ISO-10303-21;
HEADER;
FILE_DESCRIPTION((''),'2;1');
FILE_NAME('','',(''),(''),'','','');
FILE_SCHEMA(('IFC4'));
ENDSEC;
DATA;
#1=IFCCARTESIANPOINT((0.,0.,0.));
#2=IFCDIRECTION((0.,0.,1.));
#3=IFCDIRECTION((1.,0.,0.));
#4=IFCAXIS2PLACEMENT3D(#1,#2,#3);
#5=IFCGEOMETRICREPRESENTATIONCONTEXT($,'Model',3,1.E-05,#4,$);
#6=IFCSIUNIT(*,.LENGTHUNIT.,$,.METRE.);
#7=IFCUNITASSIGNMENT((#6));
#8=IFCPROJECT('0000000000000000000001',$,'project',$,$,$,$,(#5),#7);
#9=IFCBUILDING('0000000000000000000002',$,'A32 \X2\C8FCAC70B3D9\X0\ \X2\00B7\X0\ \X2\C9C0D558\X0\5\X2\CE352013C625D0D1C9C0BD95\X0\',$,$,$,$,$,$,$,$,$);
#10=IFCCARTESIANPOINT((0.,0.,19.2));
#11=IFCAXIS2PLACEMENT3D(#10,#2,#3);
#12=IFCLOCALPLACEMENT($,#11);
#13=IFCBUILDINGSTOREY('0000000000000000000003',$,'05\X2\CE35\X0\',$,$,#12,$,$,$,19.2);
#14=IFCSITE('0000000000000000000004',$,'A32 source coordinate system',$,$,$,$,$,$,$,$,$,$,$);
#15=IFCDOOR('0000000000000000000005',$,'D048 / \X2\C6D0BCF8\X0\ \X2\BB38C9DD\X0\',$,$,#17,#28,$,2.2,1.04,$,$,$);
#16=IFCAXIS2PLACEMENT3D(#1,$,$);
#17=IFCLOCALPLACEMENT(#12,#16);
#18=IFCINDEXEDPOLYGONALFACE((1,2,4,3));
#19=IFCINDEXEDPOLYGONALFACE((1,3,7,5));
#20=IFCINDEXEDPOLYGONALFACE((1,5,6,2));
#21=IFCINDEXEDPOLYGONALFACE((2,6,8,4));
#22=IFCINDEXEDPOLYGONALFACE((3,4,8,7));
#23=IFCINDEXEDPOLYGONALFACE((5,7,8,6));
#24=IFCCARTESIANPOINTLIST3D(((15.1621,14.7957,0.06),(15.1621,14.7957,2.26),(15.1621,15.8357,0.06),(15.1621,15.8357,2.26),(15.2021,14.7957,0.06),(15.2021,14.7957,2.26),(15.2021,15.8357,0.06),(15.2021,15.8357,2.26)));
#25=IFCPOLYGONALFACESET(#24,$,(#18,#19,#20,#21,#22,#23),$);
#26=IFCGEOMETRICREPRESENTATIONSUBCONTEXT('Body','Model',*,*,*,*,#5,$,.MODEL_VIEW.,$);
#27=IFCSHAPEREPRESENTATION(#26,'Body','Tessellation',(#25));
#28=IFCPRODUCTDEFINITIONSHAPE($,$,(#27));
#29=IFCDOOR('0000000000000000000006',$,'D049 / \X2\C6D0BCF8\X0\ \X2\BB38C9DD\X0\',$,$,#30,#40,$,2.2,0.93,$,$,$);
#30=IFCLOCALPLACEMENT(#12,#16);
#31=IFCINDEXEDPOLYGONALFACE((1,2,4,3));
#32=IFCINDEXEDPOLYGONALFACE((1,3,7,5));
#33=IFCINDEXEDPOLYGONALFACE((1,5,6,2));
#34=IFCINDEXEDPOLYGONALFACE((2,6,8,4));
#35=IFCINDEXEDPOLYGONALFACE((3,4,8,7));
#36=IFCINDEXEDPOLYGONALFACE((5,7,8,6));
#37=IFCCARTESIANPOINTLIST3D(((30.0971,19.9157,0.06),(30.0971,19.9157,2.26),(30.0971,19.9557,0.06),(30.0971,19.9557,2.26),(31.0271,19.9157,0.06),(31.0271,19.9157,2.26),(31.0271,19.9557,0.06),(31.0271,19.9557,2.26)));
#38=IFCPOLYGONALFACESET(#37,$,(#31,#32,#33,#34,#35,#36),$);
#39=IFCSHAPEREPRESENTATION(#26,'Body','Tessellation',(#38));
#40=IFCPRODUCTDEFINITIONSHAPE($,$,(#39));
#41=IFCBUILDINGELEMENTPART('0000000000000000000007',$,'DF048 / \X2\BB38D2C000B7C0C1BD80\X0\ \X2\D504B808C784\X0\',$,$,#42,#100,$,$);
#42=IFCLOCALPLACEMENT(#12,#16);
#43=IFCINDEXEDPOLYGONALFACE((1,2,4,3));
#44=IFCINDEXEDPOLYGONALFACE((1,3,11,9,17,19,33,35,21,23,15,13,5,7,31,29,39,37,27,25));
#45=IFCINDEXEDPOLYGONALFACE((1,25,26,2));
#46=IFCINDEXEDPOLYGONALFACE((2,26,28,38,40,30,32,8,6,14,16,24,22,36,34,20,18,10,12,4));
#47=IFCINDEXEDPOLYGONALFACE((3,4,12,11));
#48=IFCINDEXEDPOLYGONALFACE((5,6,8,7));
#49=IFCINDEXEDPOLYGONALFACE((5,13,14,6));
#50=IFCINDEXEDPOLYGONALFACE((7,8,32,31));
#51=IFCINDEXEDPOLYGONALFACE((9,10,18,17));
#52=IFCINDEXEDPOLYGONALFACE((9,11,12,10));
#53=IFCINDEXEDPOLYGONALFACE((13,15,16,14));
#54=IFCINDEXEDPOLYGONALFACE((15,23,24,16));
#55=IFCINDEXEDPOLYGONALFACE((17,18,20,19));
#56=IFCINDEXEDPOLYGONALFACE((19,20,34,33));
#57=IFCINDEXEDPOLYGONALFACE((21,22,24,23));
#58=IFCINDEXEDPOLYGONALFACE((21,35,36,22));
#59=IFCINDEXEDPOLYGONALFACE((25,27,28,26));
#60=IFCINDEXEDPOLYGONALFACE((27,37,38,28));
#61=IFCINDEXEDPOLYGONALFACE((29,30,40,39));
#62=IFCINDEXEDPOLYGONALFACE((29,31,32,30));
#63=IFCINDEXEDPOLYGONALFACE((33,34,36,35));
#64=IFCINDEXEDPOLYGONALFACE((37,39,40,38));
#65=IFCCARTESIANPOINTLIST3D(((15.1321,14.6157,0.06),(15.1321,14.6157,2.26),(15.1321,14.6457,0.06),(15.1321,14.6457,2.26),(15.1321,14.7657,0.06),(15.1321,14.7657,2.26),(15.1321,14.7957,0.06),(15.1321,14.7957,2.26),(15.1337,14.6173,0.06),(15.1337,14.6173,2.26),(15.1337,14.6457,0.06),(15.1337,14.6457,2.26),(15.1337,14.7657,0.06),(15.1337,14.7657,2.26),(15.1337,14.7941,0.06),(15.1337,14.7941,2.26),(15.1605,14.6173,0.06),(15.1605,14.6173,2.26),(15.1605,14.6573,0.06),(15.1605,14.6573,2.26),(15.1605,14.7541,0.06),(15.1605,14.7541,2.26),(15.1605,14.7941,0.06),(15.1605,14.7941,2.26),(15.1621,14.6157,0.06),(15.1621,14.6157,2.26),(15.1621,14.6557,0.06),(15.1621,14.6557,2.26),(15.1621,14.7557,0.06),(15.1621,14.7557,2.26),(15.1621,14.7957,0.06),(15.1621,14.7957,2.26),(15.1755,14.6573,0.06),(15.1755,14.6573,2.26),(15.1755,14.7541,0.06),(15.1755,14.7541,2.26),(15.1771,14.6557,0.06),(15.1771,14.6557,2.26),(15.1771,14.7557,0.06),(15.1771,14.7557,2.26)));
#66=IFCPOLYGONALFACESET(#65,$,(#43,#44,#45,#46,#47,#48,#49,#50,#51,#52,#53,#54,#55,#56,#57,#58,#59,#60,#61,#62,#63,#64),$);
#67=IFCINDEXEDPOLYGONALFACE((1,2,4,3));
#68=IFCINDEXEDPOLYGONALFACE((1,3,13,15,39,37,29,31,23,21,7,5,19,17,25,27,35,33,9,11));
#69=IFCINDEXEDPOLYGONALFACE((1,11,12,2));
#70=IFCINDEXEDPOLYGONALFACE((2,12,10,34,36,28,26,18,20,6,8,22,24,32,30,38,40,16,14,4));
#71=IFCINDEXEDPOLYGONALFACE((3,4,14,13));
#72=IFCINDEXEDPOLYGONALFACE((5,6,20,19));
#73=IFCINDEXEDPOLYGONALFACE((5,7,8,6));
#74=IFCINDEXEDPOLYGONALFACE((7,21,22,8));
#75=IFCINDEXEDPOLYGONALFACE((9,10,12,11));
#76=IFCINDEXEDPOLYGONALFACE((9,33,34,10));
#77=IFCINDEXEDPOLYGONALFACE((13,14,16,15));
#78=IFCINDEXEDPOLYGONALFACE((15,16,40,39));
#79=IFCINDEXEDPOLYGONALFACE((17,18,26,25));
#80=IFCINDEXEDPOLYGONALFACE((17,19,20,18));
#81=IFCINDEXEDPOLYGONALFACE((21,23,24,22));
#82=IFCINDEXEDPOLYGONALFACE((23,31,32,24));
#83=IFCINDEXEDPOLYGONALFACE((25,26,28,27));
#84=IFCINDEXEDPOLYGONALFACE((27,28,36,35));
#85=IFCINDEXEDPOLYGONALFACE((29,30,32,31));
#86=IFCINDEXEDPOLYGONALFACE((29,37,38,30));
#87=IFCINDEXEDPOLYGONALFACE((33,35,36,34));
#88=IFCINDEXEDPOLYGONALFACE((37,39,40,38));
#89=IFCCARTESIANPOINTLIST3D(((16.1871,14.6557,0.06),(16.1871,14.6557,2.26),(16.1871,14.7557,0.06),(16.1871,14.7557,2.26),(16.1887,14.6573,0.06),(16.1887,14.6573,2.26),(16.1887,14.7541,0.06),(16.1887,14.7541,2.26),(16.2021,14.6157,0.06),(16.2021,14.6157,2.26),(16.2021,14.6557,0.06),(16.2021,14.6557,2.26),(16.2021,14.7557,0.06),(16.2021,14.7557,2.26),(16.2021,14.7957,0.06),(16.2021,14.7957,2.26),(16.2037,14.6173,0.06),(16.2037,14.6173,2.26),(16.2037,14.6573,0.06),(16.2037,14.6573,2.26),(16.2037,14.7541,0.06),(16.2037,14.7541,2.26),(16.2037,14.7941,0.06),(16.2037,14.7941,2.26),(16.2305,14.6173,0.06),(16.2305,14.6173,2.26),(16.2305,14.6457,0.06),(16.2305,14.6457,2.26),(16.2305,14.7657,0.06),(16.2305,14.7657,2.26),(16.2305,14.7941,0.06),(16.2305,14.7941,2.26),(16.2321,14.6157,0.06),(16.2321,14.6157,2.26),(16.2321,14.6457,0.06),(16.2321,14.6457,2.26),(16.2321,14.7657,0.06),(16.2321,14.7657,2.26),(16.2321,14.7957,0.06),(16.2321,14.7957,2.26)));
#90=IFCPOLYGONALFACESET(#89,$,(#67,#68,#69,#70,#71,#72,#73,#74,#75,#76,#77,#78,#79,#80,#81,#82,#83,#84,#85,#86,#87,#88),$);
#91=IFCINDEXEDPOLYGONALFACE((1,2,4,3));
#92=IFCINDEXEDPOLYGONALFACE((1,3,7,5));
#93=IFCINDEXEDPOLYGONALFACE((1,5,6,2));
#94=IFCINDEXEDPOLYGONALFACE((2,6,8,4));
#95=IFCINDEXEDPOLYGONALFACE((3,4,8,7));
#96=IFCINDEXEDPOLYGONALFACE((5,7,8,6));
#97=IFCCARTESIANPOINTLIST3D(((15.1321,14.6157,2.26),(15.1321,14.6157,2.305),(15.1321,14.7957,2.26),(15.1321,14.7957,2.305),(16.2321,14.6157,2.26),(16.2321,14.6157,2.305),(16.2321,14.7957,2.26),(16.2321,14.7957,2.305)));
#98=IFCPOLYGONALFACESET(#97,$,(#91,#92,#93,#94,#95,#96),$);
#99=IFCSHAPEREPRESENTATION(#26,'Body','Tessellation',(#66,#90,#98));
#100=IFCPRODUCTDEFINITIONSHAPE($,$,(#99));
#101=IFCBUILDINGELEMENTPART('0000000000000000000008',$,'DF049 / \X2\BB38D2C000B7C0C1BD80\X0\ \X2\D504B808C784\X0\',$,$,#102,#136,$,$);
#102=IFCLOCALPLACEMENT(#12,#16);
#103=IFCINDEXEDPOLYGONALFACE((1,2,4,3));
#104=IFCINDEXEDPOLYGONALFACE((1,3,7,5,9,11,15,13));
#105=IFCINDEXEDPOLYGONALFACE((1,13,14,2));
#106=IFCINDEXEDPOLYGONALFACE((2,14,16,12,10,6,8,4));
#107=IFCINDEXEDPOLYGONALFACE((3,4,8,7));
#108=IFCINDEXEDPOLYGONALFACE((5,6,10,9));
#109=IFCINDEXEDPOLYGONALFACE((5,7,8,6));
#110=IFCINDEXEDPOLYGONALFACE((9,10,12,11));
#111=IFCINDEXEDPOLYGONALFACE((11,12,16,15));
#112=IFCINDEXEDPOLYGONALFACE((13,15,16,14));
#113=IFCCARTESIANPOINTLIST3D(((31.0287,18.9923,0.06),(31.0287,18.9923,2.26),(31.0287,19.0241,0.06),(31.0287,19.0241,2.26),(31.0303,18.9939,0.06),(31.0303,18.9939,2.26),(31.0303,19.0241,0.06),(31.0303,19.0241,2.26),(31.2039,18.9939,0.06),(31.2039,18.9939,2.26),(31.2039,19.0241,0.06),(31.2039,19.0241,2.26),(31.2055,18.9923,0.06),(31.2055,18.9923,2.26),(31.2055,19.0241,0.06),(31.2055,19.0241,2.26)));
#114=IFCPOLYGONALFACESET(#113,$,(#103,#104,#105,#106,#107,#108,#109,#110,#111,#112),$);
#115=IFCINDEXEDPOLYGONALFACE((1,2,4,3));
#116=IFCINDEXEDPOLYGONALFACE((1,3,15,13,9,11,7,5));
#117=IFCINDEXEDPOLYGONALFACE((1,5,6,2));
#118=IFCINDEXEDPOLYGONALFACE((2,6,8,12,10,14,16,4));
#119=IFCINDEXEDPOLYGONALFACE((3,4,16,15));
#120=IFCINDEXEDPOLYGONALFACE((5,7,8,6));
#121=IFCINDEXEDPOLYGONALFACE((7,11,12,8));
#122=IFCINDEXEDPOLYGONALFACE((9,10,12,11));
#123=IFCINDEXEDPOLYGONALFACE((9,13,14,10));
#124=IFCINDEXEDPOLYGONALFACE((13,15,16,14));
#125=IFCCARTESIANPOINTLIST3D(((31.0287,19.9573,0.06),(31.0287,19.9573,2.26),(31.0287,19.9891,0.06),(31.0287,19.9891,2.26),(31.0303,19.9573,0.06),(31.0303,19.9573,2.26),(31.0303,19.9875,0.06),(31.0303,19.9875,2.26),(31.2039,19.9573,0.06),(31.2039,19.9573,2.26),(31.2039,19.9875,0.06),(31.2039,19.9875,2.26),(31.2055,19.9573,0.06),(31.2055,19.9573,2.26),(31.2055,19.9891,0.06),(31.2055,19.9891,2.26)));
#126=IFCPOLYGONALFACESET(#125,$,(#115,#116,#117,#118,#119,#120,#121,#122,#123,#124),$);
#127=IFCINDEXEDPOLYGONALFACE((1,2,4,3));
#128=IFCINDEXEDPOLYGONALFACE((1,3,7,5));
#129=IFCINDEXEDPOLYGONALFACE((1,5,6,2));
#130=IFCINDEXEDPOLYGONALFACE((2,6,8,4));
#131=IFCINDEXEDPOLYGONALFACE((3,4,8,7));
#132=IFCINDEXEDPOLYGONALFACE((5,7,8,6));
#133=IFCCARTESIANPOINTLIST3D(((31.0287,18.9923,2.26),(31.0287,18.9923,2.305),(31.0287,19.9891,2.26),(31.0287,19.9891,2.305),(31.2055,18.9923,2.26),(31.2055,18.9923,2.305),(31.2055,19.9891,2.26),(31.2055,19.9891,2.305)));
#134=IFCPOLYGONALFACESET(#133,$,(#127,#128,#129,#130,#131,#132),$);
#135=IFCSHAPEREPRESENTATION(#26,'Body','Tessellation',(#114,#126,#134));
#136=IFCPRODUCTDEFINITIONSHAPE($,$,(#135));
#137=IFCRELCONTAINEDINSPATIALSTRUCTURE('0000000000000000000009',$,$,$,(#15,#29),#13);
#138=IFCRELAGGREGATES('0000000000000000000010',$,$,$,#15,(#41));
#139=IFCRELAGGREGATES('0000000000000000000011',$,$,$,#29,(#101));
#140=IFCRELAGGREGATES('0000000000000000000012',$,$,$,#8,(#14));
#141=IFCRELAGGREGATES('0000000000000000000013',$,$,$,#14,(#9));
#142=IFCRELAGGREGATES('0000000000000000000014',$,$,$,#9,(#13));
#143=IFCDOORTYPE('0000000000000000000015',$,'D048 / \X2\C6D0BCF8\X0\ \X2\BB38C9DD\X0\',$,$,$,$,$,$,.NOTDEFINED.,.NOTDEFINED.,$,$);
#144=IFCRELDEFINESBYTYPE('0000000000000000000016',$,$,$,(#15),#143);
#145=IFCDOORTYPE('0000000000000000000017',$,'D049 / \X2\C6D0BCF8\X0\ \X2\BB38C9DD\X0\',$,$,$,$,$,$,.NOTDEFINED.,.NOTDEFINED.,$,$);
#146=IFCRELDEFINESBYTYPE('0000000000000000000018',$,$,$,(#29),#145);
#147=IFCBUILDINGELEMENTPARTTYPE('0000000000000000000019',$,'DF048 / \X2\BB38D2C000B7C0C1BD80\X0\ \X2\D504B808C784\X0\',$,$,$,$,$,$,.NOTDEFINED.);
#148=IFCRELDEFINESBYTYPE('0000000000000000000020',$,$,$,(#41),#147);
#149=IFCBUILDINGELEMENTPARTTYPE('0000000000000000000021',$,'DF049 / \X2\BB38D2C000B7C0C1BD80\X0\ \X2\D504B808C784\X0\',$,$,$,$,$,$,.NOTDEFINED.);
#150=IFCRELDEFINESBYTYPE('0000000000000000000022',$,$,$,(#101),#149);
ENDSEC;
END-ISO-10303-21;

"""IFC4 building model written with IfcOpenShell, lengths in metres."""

from ifc_helpers import new_model, si_unit, frame, origin, origin_with_axes, place, context, subcontext, project, spatial, polyline, outline, extrude, source, transform, mapped, type_object, type_shapes, element, aggregate, save


model = new_model("IFC4")

# Units and contexts
model_context = context("Model", 3, precision=1e-05, world=origin_with_axes())
body_context = subcontext(model_context, "Body", "Model", "MODEL_VIEW")
ifc_project = project(units=[si_unit("LENGTHUNIT", "METRE")], contexts=[model_context])

# Site, building, storey
storey_placement = place(None, frame((0.0, 0.0, 19.2), z_axis=(0.0, 0.0, 1.0), x_axis=(1.0, 0.0, 0.0)))
site = spatial("IfcSite", under=ifc_project, Name="A32 source coordinate system")
building = spatial("IfcBuilding", under=site, Name="A32 주거동 · 지하5층–옥탑지붕")
storey = spatial("IfcBuildingStorey", under=building, at=storey_placement, Name="05층", Elevation=19.2)

# Doors
door_type_1 = type_object("IfcDoorType", Name="D048 / 원본 문짝", OperationType="NOTDEFINED", PredefinedType="NOTDEFINED")
shared_shape_1 = source(origin(), body_context, "Body", "SweptSolid", [
    extrude(outline(polyline([(15.2021, 15.8357), (15.2021, 14.7957), (15.1621, 14.7957), (15.1621, 15.8357), (15.2021, 15.8357)])), frame((0.0, 0.0, 0.06)), (0.0, 0.0, 1.0), 2.2),
])
type_shapes(door_type_1, [shared_shape_1])
door_1_placement = place(storey_placement, origin_with_axes())
door_1 = element("IfcDoor", 1, at=door_1_placement, inside=storey, type_object=door_type_1, Name="D048 / 원본 문짝", OverallHeight=2.2, OverallWidth=1.04, context=body_context, shape_type="MappedRepresentation", body=[
    mapped(shared_shape_1, transform((0.0, 0.0, 0.0), scale=1.0)),
])
door_type_2 = type_object("IfcDoorType", Name="D049 / 원본 문짝", OperationType="NOTDEFINED", PredefinedType="NOTDEFINED")
shared_shape_2 = source(origin(), body_context, "Body", "SweptSolid", [
    extrude(outline(polyline([(31.0271, 19.9557), (31.0271, 19.9157), (30.0971, 19.9157), (30.0971, 19.9557), (31.0271, 19.9557)])), frame((0.0, 0.0, 0.06)), (0.0, 0.0, 1.0), 2.2),
])
type_shapes(door_type_2, [shared_shape_2])
door_2_placement = place(storey_placement, origin_with_axes())
door_2 = element("IfcDoor", 2, at=door_2_placement, inside=storey, type_object=door_type_2, Name="D049 / 원본 문짝", OverallHeight=2.2, OverallWidth=0.93, context=body_context, shape_type="MappedRepresentation", body=[
    mapped(shared_shape_2, transform((0.0, 0.0, 0.0), scale=1.0)),
])

# Building element parts
building_element_part_type_1 = type_object("IfcBuildingElementPartType", Name="DF048 / 문틀·상부 프레임", PredefinedType="NOTDEFINED")
shared_shape_3 = source(origin(), body_context, "Body", "SweptSolid", [
    extrude(outline(polyline([(15.1321, 14.7657), (15.1321, 14.7957), (15.1621, 14.7957), (15.1621, 14.7557), (15.1771, 14.7557), (15.1771, 14.6557), (15.1621, 14.6557), (15.1621, 14.6157), (15.1321, 14.6157), (15.1321, 14.6457), (15.1337, 14.6457), (15.1337, 14.6173), (15.1605, 14.6173), (15.1605, 14.6573), (15.1755, 14.6573), (15.1755, 14.7541), (15.1605, 14.7541), (15.1605, 14.7941), (15.1337, 14.7941), (15.1337, 14.7657), (15.1321, 14.7657)])), frame((0.0, 0.0, 0.06)), (0.0, 0.0, 1.0), 2.2),
    extrude(outline(polyline([(16.2305, 14.7941), (16.2037, 14.7941), (16.2037, 14.7541), (16.1887, 14.7541), (16.1887, 14.6573), (16.2037, 14.6573), (16.2037, 14.6173), (16.2305, 14.6173), (16.2305, 14.6457), (16.2321, 14.6457), (16.2321, 14.6157), (16.2021, 14.6157), (16.2021, 14.6557), (16.1871, 14.6557), (16.1871, 14.7557), (16.2021, 14.7557), (16.2021, 14.7957), (16.2321, 14.7957), (16.2321, 14.7657), (16.2305, 14.7657), (16.2305, 14.7941)])), frame((0.0, 0.0, 0.06)), (0.0, 0.0, 1.0), 2.2),
    extrude(outline(polyline([(15.1321, 14.6157), (15.1321, 14.7957), (16.2321, 14.7957), (16.2321, 14.6157), (15.1321, 14.6157)])), frame((0.0, 0.0, 2.26)), (0.0, 0.0, 1.0), 0.045),
])
type_shapes(building_element_part_type_1, [shared_shape_3])
building_element_part_1_placement = place(door_1_placement, origin_with_axes())
building_element_part_1 = element("IfcBuildingElementPart", 3, at=building_element_part_1_placement, type_object=building_element_part_type_1, Name="DF048 / 문틀·상부 프레임", context=body_context, shape_type="MappedRepresentation", body=[
    mapped(shared_shape_3, transform((0.0, 0.0, 0.0), scale=1.0)),
])
aggregate(door_1, [building_element_part_1])
building_element_part_type_2 = type_object("IfcBuildingElementPartType", Name="DF049 / 문틀·상부 프레임", PredefinedType="NOTDEFINED")
shared_shape_4 = source(origin(), body_context, "Body", "SweptSolid", [
    extrude(outline(polyline([(31.0303, 19.0241), (31.0303, 18.9939), (31.2039, 18.9939), (31.2039, 19.0241), (31.2055, 19.0241), (31.2055, 18.9923), (31.0287, 18.9923), (31.0287, 19.0241), (31.0303, 19.0241)])), frame((0.0, 0.0, 0.06)), (0.0, 0.0, 1.0), 2.2),
    extrude(outline(polyline([(31.0287, 19.9891), (31.2055, 19.9891), (31.2055, 19.9573), (31.2039, 19.9573), (31.2039, 19.9875), (31.0303, 19.9875), (31.0303, 19.9573), (31.0287, 19.9573), (31.0287, 19.9891)])), frame((0.0, 0.0, 0.06)), (0.0, 0.0, 1.0), 2.2),
    extrude(outline(polyline([(31.0287, 18.9923), (31.0287, 19.9891), (31.2055, 19.9891), (31.2055, 18.9923), (31.0287, 18.9923)])), frame((0.0, 0.0, 2.26)), (0.0, 0.0, 1.0), 0.045),
])
type_shapes(building_element_part_type_2, [shared_shape_4])
building_element_part_2_placement = place(door_2_placement, origin_with_axes())
building_element_part_2 = element("IfcBuildingElementPart", 4, at=building_element_part_2_placement, type_object=building_element_part_type_2, Name="DF049 / 문틀·상부 프레임", context=body_context, shape_type="MappedRepresentation", body=[
    mapped(shared_shape_4, transform((0.0, 0.0, 0.0), scale=1.0)),
])
aggregate(door_2, [building_element_part_2])

save(model, "model.ifc")
